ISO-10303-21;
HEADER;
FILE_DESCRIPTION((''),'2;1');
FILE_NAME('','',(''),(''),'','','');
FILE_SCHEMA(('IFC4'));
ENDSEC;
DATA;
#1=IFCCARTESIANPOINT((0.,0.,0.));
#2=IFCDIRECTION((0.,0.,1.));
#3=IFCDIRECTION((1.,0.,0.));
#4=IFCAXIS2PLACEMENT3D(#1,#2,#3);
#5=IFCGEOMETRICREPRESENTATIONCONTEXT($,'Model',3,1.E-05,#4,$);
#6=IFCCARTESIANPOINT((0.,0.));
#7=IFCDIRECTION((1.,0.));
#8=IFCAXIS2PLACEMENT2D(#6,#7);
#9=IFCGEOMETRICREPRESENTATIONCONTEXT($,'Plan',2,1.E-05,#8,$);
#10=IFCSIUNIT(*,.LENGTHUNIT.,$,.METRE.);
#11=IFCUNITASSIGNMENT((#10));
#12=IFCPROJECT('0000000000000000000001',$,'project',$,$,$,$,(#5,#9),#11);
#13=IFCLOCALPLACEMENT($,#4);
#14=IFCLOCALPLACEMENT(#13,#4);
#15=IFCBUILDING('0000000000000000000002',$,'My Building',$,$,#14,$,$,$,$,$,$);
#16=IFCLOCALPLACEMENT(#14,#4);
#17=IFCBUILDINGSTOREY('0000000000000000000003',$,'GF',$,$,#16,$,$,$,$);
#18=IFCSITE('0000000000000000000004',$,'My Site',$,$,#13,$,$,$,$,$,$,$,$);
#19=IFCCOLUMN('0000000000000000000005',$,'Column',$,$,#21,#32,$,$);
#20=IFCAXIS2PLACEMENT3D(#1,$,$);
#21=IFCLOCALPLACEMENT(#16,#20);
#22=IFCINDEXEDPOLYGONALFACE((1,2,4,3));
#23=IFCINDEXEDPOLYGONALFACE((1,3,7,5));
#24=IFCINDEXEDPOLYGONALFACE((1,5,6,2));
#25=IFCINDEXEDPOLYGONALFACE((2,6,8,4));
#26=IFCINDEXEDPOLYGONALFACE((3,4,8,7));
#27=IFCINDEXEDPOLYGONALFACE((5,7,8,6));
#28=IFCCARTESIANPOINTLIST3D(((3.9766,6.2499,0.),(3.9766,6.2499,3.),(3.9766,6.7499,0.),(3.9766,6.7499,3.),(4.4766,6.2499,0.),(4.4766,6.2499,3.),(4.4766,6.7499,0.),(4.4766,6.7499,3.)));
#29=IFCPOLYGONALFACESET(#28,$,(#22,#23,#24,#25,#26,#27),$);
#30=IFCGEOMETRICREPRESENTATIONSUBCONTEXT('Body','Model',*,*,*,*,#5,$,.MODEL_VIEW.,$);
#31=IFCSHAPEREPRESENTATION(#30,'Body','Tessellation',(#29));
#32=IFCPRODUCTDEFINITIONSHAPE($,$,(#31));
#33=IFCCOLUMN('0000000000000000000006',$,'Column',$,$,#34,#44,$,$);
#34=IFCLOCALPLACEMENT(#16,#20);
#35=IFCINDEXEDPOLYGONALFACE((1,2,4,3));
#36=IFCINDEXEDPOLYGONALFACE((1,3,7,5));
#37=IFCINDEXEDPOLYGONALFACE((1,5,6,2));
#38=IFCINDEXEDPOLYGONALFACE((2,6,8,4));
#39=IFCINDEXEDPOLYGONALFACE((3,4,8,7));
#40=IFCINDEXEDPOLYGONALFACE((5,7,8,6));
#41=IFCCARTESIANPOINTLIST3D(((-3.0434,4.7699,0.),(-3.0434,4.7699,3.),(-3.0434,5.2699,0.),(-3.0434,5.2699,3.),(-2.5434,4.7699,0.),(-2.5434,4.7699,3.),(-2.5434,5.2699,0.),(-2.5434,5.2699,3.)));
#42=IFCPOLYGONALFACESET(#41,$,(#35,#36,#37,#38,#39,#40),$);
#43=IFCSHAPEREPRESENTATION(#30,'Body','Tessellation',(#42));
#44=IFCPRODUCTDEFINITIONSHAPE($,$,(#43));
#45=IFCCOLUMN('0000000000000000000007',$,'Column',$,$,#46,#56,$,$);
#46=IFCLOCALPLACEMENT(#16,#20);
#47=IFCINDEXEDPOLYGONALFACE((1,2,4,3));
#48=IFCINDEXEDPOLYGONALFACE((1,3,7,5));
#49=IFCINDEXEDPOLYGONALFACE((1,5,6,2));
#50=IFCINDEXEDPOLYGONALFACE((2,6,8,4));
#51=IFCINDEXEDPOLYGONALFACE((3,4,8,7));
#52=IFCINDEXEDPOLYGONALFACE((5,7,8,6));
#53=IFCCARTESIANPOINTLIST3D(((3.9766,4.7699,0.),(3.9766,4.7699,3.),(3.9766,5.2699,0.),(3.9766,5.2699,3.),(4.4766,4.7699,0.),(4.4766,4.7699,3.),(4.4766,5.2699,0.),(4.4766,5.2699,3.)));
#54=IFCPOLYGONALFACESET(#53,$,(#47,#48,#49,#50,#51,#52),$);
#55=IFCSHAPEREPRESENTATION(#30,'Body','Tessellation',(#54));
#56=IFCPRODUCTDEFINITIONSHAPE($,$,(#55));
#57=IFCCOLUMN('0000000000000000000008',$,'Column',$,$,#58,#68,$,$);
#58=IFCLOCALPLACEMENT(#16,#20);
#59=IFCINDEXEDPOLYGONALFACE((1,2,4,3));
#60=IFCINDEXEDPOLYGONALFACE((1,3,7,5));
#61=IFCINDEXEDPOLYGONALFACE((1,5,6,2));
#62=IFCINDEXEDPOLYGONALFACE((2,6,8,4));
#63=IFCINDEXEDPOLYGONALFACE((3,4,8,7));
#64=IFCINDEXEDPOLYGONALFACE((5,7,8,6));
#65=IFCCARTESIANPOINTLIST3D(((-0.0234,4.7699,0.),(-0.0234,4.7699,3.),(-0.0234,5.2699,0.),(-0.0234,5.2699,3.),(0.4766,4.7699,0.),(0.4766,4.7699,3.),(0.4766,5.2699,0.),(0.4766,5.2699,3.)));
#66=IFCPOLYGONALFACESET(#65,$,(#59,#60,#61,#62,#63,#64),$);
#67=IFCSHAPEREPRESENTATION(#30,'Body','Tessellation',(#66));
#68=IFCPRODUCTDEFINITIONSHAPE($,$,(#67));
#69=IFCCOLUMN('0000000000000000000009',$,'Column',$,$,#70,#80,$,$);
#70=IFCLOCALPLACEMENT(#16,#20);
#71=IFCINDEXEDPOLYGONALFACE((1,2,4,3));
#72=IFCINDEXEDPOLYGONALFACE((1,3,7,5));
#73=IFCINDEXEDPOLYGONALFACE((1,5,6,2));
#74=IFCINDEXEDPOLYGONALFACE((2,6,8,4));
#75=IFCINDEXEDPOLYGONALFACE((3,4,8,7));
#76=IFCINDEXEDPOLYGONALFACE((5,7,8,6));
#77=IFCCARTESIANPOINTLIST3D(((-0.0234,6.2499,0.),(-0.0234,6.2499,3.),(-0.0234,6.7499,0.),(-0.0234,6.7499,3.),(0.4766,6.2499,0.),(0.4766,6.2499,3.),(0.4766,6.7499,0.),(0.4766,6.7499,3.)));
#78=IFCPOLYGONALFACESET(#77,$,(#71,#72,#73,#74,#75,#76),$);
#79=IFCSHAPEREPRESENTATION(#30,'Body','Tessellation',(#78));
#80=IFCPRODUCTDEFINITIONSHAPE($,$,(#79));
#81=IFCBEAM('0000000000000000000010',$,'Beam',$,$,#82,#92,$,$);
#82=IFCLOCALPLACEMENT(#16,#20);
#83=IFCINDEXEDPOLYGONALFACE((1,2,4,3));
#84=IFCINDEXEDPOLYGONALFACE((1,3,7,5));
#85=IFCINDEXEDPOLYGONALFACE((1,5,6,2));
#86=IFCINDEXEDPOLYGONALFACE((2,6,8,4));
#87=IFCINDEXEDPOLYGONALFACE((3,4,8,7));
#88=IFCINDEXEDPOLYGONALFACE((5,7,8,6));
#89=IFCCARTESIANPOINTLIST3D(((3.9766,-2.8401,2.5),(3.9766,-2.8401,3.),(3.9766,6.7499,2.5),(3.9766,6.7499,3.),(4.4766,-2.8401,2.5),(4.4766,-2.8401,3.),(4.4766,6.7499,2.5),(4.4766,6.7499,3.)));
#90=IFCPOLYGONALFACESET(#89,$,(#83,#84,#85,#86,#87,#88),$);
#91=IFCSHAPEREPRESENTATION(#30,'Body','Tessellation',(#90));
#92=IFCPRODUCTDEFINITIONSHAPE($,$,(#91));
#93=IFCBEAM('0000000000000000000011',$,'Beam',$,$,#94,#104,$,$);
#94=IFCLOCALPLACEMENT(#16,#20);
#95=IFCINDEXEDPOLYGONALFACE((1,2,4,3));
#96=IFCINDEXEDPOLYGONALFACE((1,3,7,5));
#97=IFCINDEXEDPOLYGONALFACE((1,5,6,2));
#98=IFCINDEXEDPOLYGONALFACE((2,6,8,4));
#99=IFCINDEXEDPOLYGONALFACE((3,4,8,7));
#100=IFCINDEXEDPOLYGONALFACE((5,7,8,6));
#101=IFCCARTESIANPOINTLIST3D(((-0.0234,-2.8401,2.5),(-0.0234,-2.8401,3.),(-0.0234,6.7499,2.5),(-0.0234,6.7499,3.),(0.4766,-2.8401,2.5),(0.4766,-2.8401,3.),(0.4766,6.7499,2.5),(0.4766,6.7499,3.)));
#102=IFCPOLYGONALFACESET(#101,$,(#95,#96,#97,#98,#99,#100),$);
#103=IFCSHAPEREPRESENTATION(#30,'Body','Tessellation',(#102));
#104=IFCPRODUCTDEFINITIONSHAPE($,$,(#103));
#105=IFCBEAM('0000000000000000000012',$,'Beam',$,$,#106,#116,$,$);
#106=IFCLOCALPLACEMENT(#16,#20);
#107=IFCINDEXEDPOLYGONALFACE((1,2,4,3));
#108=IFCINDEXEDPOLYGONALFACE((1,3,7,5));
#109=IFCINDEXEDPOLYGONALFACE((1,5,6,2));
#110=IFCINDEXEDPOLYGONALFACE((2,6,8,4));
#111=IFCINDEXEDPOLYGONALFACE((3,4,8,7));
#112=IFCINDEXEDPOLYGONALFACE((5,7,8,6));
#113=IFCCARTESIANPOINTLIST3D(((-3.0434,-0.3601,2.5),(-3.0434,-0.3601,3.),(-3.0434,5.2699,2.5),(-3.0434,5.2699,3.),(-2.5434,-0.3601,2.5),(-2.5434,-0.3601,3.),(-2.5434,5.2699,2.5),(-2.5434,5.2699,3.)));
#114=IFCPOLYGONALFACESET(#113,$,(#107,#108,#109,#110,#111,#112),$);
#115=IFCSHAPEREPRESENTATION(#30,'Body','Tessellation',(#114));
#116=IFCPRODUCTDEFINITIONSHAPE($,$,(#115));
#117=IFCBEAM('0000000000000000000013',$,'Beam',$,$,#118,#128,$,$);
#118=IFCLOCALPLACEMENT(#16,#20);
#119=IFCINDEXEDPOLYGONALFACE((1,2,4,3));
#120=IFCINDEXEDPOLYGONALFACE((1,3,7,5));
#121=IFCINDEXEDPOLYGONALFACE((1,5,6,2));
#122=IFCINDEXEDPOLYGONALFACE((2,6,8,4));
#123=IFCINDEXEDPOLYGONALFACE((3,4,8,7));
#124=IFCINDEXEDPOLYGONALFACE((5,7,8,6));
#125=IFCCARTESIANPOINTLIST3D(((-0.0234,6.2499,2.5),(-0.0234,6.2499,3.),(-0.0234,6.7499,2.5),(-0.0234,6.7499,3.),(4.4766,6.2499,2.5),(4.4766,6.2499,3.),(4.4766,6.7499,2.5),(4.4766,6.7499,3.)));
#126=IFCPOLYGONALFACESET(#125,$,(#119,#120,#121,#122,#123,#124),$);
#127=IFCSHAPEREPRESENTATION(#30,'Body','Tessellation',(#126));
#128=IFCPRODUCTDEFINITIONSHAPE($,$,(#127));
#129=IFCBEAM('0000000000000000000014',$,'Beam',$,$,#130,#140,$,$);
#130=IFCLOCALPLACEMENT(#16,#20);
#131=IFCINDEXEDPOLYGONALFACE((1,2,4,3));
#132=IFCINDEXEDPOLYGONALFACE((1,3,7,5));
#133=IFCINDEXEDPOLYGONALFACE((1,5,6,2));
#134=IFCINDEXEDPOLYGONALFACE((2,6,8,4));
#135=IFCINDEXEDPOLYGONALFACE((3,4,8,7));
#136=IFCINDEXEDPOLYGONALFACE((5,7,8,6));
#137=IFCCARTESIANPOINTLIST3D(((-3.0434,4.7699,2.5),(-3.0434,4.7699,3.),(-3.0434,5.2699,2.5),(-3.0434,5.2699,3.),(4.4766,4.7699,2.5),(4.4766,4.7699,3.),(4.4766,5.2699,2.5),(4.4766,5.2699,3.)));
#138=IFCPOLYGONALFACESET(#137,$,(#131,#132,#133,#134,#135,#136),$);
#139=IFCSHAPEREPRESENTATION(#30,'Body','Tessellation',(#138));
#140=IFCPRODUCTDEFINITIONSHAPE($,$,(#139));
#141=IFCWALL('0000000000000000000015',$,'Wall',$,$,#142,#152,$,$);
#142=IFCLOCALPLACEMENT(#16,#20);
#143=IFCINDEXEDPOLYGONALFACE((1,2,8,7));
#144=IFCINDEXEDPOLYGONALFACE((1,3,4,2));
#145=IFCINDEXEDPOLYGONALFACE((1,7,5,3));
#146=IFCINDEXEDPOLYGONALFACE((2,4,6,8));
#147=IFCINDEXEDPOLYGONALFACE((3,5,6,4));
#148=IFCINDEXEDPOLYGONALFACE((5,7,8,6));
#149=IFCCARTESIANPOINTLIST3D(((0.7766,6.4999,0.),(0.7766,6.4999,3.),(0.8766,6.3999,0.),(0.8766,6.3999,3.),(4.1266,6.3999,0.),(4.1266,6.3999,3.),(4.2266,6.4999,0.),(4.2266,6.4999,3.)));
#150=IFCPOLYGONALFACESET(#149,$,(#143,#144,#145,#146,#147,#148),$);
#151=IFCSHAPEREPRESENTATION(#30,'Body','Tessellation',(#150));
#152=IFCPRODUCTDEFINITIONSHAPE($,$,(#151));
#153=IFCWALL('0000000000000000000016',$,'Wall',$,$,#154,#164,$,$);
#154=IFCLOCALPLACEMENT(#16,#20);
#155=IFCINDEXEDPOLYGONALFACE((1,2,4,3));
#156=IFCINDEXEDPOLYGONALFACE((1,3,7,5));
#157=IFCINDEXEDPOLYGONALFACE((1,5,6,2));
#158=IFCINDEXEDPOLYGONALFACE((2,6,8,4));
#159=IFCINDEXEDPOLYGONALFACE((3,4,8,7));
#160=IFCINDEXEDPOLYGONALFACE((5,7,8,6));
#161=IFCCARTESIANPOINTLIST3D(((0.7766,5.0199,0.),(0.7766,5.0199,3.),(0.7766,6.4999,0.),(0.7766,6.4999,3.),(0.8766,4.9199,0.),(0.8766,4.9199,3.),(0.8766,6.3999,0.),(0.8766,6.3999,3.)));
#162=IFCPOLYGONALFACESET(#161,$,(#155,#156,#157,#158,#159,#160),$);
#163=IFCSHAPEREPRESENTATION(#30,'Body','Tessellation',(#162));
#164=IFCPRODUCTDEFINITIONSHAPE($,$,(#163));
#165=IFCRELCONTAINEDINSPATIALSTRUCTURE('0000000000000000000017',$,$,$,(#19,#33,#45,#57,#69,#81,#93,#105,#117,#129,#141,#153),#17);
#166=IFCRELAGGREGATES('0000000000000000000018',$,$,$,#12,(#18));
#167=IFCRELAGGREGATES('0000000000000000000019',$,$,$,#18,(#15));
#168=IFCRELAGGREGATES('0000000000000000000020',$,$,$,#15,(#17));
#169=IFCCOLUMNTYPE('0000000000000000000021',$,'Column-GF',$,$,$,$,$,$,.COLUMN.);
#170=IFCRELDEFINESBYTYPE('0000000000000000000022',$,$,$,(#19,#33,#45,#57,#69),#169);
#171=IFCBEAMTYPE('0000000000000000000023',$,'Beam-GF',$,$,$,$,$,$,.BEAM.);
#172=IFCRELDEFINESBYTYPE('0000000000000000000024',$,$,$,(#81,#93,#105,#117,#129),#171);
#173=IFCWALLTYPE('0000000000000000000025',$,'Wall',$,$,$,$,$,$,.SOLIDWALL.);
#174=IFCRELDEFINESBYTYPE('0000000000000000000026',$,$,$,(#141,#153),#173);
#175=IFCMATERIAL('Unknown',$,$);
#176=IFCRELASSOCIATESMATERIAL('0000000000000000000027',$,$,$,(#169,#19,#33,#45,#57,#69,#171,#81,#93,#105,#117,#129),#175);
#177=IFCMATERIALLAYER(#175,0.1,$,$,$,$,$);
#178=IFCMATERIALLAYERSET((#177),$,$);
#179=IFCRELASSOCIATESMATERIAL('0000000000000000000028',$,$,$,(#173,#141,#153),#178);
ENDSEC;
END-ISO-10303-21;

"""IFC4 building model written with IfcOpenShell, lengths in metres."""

from ifc_helpers import new_model, si_unit, frame, origin_with_axes, origin_2d_with_axis, place, context, subcontext, project, spatial, line, indexed_curve, rectangle, outline, extrude, material, layer, layer_set, layer_usage, material_profile, profile_set, profile_usage, type_object, element, save


model = new_model("IFC4")

# Units and contexts
model_context = context("Model", 3, precision=1e-05, world=origin_with_axes())
plan_context = context("Plan", 2, precision=1e-05, world=origin_2d_with_axis())
body_context_1 = subcontext(model_context, "Body", "Model", "MODEL_VIEW")
ifc_project = project(units=[si_unit("LENGTHUNIT", "METRE")], contexts=[model_context, plan_context])

# Site, building, storey
site_placement = place(None, origin_with_axes())
site = spatial("IfcSite", under=ifc_project, at=site_placement, Name="My Site")
building_placement = place(site_placement, origin_with_axes())
building = spatial("IfcBuilding", under=site, at=building_placement, Name="My Building")
storey_placement = place(building_placement, origin_with_axes())
storey = spatial("IfcBuildingStorey", under=building, at=storey_placement, Name="GF")

# Columns
ifc_material_1 = material(Name="Unknown")
ifc_material_profile_1 = material_profile(ifc_material_1, rectangle(XDim=0.5, YDim=0.5))
ifc_profile_set_1 = profile_set([ifc_material_profile_1])
ifc_profile_usage_1 = profile_usage(ifc_profile_set_1, cardinal=5)
column_type = type_object("IfcColumnType", Name="Column-GF", PredefinedType="COLUMN", material=ifc_profile_set_1)
column_1_placement = place(storey_placement, frame((4.2266, 6.4999, 0.0), z_axis=(0.0, 0.0, 1.0), x_axis=(1.0, 0.0, 0.0)))
element("IfcColumn", 1, at=column_1_placement, inside=storey, type_object=column_type, material=ifc_profile_usage_1, Name="Column", context=body_context_1, shape_type="SweptSolid", body=[
    extrude(rectangle(XDim=0.5, YDim=0.5), origin_with_axes(), (0.0, 0.0, 1.0), 3.0),
])
ifc_profile_usage_2 = profile_usage(ifc_profile_set_1, cardinal=5)
column_2_placement = place(storey_placement, frame((-2.7934, 5.0199, 0.0), z_axis=(0.0, 0.0, 1.0), x_axis=(1.0, 0.0, 0.0)))
element("IfcColumn", 2, at=column_2_placement, inside=storey, type_object=column_type, material=ifc_profile_usage_2, Name="Column", context=body_context_1, shape_type="SweptSolid", body=[
    extrude(rectangle(XDim=0.5, YDim=0.5), origin_with_axes(), (0.0, 0.0, 1.0), 3.0),
])
ifc_profile_usage_3 = profile_usage(ifc_profile_set_1, cardinal=5)
column_3_placement = place(storey_placement, frame((4.2266, 5.0199, 0.0), z_axis=(0.0, 0.0, 1.0), x_axis=(1.0, 0.0, 0.0)))
element("IfcColumn", 3, at=column_3_placement, inside=storey, type_object=column_type, material=ifc_profile_usage_3, Name="Column", context=body_context_1, shape_type="SweptSolid", body=[
    extrude(rectangle(XDim=0.5, YDim=0.5), origin_with_axes(), (0.0, 0.0, 1.0), 3.0),
])
ifc_profile_usage_4 = profile_usage(ifc_profile_set_1, cardinal=5)
column_4_placement = place(storey_placement, frame((0.2266, 5.0199, 0.0), z_axis=(0.0, 0.0, 1.0), x_axis=(1.0, 0.0, 0.0)))
element("IfcColumn", 4, at=column_4_placement, inside=storey, type_object=column_type, material=ifc_profile_usage_4, Name="Column", context=body_context_1, shape_type="SweptSolid", body=[
    extrude(rectangle(XDim=0.5, YDim=0.5), origin_with_axes(), (0.0, 0.0, 1.0), 3.0),
])
ifc_profile_usage_5 = profile_usage(ifc_profile_set_1, cardinal=5)
column_5_placement = place(storey_placement, frame((0.2266, 6.4999, 0.0), z_axis=(0.0, 0.0, 1.0), x_axis=(1.0, 0.0, 0.0)))
element("IfcColumn", 5, at=column_5_placement, inside=storey, type_object=column_type, material=ifc_profile_usage_5, Name="Column", context=body_context_1, shape_type="SweptSolid", body=[
    extrude(rectangle(XDim=0.5, YDim=0.5), origin_with_axes(), (0.0, 0.0, 1.0), 3.0),
])

# Beams
ifc_material_profile_2 = material_profile(ifc_material_1, rectangle(XDim=0.5, YDim=0.5))
ifc_profile_set_2 = profile_set([ifc_material_profile_2])
ifc_profile_usage_6 = profile_usage(ifc_profile_set_2, cardinal=7)
beam_type = type_object("IfcBeamType", Name="Beam-GF", PredefinedType="BEAM", material=ifc_profile_set_2)
beam_1_placement = place(storey_placement, frame((4.4766, 6.7499, 3.0), z_axis=(0.0, -1.0, 0.0), x_axis=(1.0, 0.0, 0.0)))
element("IfcBeam", 6, at=beam_1_placement, inside=storey, type_object=beam_type, material=ifc_profile_usage_6, Name="Beam", context=body_context_1, shape_type="SweptSolid", body=[
    extrude(rectangle(XDim=0.5, YDim=0.5), frame((-0.25, -0.25, 0.0), z_axis=(0.0, 0.0, 1.0), x_axis=(1.0, 0.0, 0.0)), (0.0, 0.0, 1.0), 9.59),
])
ifc_profile_usage_7 = profile_usage(ifc_profile_set_2, cardinal=7)
beam_2_placement = place(storey_placement, frame((0.4766, 6.7499, 3.0), z_axis=(0.0, -1.0, 0.0), x_axis=(1.0, 0.0, 0.0)))
element("IfcBeam", 7, at=beam_2_placement, inside=storey, type_object=beam_type, material=ifc_profile_usage_7, Name="Beam", context=body_context_1, shape_type="SweptSolid", body=[
    extrude(rectangle(XDim=0.5, YDim=0.5), frame((-0.25, -0.25, 0.0), z_axis=(0.0, 0.0, 1.0), x_axis=(1.0, 0.0, 0.0)), (0.0, 0.0, 1.0), 9.59),
])
ifc_profile_usage_8 = profile_usage(ifc_profile_set_2, cardinal=7)
beam_3_placement = place(storey_placement, frame((-2.5434, 5.2699, 3.0), z_axis=(0.0, -1.0, 0.0), x_axis=(1.0, 0.0, 0.0)))
element("IfcBeam", 8, at=beam_3_placement, inside=storey, type_object=beam_type, material=ifc_profile_usage_8, Name="Beam", context=body_context_1, shape_type="SweptSolid", body=[
    extrude(rectangle(XDim=0.5, YDim=0.5), frame((-0.25, -0.25, 0.0), z_axis=(0.0, 0.0, 1.0), x_axis=(1.0, 0.0, 0.0)), (0.0, 0.0, 1.0), 5.63),
])
ifc_profile_usage_9 = profile_usage(ifc_profile_set_2, cardinal=7)
beam_4_placement = place(storey_placement, frame((4.4766, 6.2499, 3.0), z_axis=(-1.0, 0.0, 0.0), x_axis=(0.0, -1.0, 0.0)))
element("IfcBeam", 9, at=beam_4_placement, inside=storey, type_object=beam_type, material=ifc_profile_usage_9, Name="Beam", context=body_context_1, shape_type="SweptSolid", body=[
    extrude(rectangle(XDim=0.5, YDim=0.5), frame((-0.25, -0.25, 0.0), z_axis=(0.0, 0.0, 1.0), x_axis=(1.0, 0.0, 0.0)), (0.0, 0.0, 1.0), 4.5),
])
ifc_profile_usage_10 = profile_usage(ifc_profile_set_2, cardinal=7)
beam_5_placement = place(storey_placement, frame((4.4766, 4.7699, 3.0), z_axis=(-1.0, 0.0, 0.0), x_axis=(0.0, -1.0, 0.0)))
element("IfcBeam", 10, at=beam_5_placement, inside=storey, type_object=beam_type, material=ifc_profile_usage_10, Name="Beam", context=body_context_1, shape_type="SweptSolid", body=[
    extrude(rectangle(XDim=0.5, YDim=0.5), frame((-0.25, -0.25, 0.0), z_axis=(0.0, 0.0, 1.0), x_axis=(1.0, 0.0, 0.0)), (0.0, 0.0, 1.0), 7.52),
])

# Walls
ifc_layer_1 = layer(ifc_material_1, 0.1)
ifc_layer_set_1 = layer_set([ifc_layer_1])
ifc_layer_usage_1 = layer_usage(ifc_layer_set_1, "AXIS2", "POSITIVE", 0.0)
wall_type = type_object("IfcWallType", Name="Wall", PredefinedType="SOLIDWALL", material=ifc_layer_set_1)
wall_1_placement = place(storey_placement, frame((4.2266, 6.4999, 0.0), z_axis=(0.0, 0.0, 1.0), x_axis=(-1.0, 0.0, 0.0)))
element("IfcWall", 11, at=wall_1_placement, inside=storey, type_object=wall_type, material=ifc_layer_usage_1, Name="Wall", context=body_context_1, shape_type="SweptSolid", body=[
    extrude(outline(indexed_curve([(0.0, 0.0), (0.1, 0.1), (3.35, 0.1), (3.45, 0.0)], segments=[line(1, 2, 3, 4, 1)])), origin_with_axes(), (0.0, 0.0, 1.0), 3.0),
])
ifc_layer_usage_2 = layer_usage(ifc_layer_set_1, "AXIS2", "POSITIVE", 0.0)
wall_2_placement = place(storey_placement, frame((0.7766, 6.4999, 0.0), z_axis=(0.0, 0.0, 1.0), x_axis=(0.0, -1.0, 0.0)))
element("IfcWall", 12, at=wall_2_placement, inside=storey, type_object=wall_type, material=ifc_layer_usage_2, Name="Wall", context=body_context_1, shape_type="SweptSolid", body=[
    extrude(outline(indexed_curve([(0.0, 0.0), (0.1, 0.1), (1.58, 0.1), (1.48, 0.0)], segments=[line(1, 2, 3, 4, 1)])), origin_with_axes(), (0.0, 0.0, 1.0), 3.0),
])

save(model, "model.ifc")
